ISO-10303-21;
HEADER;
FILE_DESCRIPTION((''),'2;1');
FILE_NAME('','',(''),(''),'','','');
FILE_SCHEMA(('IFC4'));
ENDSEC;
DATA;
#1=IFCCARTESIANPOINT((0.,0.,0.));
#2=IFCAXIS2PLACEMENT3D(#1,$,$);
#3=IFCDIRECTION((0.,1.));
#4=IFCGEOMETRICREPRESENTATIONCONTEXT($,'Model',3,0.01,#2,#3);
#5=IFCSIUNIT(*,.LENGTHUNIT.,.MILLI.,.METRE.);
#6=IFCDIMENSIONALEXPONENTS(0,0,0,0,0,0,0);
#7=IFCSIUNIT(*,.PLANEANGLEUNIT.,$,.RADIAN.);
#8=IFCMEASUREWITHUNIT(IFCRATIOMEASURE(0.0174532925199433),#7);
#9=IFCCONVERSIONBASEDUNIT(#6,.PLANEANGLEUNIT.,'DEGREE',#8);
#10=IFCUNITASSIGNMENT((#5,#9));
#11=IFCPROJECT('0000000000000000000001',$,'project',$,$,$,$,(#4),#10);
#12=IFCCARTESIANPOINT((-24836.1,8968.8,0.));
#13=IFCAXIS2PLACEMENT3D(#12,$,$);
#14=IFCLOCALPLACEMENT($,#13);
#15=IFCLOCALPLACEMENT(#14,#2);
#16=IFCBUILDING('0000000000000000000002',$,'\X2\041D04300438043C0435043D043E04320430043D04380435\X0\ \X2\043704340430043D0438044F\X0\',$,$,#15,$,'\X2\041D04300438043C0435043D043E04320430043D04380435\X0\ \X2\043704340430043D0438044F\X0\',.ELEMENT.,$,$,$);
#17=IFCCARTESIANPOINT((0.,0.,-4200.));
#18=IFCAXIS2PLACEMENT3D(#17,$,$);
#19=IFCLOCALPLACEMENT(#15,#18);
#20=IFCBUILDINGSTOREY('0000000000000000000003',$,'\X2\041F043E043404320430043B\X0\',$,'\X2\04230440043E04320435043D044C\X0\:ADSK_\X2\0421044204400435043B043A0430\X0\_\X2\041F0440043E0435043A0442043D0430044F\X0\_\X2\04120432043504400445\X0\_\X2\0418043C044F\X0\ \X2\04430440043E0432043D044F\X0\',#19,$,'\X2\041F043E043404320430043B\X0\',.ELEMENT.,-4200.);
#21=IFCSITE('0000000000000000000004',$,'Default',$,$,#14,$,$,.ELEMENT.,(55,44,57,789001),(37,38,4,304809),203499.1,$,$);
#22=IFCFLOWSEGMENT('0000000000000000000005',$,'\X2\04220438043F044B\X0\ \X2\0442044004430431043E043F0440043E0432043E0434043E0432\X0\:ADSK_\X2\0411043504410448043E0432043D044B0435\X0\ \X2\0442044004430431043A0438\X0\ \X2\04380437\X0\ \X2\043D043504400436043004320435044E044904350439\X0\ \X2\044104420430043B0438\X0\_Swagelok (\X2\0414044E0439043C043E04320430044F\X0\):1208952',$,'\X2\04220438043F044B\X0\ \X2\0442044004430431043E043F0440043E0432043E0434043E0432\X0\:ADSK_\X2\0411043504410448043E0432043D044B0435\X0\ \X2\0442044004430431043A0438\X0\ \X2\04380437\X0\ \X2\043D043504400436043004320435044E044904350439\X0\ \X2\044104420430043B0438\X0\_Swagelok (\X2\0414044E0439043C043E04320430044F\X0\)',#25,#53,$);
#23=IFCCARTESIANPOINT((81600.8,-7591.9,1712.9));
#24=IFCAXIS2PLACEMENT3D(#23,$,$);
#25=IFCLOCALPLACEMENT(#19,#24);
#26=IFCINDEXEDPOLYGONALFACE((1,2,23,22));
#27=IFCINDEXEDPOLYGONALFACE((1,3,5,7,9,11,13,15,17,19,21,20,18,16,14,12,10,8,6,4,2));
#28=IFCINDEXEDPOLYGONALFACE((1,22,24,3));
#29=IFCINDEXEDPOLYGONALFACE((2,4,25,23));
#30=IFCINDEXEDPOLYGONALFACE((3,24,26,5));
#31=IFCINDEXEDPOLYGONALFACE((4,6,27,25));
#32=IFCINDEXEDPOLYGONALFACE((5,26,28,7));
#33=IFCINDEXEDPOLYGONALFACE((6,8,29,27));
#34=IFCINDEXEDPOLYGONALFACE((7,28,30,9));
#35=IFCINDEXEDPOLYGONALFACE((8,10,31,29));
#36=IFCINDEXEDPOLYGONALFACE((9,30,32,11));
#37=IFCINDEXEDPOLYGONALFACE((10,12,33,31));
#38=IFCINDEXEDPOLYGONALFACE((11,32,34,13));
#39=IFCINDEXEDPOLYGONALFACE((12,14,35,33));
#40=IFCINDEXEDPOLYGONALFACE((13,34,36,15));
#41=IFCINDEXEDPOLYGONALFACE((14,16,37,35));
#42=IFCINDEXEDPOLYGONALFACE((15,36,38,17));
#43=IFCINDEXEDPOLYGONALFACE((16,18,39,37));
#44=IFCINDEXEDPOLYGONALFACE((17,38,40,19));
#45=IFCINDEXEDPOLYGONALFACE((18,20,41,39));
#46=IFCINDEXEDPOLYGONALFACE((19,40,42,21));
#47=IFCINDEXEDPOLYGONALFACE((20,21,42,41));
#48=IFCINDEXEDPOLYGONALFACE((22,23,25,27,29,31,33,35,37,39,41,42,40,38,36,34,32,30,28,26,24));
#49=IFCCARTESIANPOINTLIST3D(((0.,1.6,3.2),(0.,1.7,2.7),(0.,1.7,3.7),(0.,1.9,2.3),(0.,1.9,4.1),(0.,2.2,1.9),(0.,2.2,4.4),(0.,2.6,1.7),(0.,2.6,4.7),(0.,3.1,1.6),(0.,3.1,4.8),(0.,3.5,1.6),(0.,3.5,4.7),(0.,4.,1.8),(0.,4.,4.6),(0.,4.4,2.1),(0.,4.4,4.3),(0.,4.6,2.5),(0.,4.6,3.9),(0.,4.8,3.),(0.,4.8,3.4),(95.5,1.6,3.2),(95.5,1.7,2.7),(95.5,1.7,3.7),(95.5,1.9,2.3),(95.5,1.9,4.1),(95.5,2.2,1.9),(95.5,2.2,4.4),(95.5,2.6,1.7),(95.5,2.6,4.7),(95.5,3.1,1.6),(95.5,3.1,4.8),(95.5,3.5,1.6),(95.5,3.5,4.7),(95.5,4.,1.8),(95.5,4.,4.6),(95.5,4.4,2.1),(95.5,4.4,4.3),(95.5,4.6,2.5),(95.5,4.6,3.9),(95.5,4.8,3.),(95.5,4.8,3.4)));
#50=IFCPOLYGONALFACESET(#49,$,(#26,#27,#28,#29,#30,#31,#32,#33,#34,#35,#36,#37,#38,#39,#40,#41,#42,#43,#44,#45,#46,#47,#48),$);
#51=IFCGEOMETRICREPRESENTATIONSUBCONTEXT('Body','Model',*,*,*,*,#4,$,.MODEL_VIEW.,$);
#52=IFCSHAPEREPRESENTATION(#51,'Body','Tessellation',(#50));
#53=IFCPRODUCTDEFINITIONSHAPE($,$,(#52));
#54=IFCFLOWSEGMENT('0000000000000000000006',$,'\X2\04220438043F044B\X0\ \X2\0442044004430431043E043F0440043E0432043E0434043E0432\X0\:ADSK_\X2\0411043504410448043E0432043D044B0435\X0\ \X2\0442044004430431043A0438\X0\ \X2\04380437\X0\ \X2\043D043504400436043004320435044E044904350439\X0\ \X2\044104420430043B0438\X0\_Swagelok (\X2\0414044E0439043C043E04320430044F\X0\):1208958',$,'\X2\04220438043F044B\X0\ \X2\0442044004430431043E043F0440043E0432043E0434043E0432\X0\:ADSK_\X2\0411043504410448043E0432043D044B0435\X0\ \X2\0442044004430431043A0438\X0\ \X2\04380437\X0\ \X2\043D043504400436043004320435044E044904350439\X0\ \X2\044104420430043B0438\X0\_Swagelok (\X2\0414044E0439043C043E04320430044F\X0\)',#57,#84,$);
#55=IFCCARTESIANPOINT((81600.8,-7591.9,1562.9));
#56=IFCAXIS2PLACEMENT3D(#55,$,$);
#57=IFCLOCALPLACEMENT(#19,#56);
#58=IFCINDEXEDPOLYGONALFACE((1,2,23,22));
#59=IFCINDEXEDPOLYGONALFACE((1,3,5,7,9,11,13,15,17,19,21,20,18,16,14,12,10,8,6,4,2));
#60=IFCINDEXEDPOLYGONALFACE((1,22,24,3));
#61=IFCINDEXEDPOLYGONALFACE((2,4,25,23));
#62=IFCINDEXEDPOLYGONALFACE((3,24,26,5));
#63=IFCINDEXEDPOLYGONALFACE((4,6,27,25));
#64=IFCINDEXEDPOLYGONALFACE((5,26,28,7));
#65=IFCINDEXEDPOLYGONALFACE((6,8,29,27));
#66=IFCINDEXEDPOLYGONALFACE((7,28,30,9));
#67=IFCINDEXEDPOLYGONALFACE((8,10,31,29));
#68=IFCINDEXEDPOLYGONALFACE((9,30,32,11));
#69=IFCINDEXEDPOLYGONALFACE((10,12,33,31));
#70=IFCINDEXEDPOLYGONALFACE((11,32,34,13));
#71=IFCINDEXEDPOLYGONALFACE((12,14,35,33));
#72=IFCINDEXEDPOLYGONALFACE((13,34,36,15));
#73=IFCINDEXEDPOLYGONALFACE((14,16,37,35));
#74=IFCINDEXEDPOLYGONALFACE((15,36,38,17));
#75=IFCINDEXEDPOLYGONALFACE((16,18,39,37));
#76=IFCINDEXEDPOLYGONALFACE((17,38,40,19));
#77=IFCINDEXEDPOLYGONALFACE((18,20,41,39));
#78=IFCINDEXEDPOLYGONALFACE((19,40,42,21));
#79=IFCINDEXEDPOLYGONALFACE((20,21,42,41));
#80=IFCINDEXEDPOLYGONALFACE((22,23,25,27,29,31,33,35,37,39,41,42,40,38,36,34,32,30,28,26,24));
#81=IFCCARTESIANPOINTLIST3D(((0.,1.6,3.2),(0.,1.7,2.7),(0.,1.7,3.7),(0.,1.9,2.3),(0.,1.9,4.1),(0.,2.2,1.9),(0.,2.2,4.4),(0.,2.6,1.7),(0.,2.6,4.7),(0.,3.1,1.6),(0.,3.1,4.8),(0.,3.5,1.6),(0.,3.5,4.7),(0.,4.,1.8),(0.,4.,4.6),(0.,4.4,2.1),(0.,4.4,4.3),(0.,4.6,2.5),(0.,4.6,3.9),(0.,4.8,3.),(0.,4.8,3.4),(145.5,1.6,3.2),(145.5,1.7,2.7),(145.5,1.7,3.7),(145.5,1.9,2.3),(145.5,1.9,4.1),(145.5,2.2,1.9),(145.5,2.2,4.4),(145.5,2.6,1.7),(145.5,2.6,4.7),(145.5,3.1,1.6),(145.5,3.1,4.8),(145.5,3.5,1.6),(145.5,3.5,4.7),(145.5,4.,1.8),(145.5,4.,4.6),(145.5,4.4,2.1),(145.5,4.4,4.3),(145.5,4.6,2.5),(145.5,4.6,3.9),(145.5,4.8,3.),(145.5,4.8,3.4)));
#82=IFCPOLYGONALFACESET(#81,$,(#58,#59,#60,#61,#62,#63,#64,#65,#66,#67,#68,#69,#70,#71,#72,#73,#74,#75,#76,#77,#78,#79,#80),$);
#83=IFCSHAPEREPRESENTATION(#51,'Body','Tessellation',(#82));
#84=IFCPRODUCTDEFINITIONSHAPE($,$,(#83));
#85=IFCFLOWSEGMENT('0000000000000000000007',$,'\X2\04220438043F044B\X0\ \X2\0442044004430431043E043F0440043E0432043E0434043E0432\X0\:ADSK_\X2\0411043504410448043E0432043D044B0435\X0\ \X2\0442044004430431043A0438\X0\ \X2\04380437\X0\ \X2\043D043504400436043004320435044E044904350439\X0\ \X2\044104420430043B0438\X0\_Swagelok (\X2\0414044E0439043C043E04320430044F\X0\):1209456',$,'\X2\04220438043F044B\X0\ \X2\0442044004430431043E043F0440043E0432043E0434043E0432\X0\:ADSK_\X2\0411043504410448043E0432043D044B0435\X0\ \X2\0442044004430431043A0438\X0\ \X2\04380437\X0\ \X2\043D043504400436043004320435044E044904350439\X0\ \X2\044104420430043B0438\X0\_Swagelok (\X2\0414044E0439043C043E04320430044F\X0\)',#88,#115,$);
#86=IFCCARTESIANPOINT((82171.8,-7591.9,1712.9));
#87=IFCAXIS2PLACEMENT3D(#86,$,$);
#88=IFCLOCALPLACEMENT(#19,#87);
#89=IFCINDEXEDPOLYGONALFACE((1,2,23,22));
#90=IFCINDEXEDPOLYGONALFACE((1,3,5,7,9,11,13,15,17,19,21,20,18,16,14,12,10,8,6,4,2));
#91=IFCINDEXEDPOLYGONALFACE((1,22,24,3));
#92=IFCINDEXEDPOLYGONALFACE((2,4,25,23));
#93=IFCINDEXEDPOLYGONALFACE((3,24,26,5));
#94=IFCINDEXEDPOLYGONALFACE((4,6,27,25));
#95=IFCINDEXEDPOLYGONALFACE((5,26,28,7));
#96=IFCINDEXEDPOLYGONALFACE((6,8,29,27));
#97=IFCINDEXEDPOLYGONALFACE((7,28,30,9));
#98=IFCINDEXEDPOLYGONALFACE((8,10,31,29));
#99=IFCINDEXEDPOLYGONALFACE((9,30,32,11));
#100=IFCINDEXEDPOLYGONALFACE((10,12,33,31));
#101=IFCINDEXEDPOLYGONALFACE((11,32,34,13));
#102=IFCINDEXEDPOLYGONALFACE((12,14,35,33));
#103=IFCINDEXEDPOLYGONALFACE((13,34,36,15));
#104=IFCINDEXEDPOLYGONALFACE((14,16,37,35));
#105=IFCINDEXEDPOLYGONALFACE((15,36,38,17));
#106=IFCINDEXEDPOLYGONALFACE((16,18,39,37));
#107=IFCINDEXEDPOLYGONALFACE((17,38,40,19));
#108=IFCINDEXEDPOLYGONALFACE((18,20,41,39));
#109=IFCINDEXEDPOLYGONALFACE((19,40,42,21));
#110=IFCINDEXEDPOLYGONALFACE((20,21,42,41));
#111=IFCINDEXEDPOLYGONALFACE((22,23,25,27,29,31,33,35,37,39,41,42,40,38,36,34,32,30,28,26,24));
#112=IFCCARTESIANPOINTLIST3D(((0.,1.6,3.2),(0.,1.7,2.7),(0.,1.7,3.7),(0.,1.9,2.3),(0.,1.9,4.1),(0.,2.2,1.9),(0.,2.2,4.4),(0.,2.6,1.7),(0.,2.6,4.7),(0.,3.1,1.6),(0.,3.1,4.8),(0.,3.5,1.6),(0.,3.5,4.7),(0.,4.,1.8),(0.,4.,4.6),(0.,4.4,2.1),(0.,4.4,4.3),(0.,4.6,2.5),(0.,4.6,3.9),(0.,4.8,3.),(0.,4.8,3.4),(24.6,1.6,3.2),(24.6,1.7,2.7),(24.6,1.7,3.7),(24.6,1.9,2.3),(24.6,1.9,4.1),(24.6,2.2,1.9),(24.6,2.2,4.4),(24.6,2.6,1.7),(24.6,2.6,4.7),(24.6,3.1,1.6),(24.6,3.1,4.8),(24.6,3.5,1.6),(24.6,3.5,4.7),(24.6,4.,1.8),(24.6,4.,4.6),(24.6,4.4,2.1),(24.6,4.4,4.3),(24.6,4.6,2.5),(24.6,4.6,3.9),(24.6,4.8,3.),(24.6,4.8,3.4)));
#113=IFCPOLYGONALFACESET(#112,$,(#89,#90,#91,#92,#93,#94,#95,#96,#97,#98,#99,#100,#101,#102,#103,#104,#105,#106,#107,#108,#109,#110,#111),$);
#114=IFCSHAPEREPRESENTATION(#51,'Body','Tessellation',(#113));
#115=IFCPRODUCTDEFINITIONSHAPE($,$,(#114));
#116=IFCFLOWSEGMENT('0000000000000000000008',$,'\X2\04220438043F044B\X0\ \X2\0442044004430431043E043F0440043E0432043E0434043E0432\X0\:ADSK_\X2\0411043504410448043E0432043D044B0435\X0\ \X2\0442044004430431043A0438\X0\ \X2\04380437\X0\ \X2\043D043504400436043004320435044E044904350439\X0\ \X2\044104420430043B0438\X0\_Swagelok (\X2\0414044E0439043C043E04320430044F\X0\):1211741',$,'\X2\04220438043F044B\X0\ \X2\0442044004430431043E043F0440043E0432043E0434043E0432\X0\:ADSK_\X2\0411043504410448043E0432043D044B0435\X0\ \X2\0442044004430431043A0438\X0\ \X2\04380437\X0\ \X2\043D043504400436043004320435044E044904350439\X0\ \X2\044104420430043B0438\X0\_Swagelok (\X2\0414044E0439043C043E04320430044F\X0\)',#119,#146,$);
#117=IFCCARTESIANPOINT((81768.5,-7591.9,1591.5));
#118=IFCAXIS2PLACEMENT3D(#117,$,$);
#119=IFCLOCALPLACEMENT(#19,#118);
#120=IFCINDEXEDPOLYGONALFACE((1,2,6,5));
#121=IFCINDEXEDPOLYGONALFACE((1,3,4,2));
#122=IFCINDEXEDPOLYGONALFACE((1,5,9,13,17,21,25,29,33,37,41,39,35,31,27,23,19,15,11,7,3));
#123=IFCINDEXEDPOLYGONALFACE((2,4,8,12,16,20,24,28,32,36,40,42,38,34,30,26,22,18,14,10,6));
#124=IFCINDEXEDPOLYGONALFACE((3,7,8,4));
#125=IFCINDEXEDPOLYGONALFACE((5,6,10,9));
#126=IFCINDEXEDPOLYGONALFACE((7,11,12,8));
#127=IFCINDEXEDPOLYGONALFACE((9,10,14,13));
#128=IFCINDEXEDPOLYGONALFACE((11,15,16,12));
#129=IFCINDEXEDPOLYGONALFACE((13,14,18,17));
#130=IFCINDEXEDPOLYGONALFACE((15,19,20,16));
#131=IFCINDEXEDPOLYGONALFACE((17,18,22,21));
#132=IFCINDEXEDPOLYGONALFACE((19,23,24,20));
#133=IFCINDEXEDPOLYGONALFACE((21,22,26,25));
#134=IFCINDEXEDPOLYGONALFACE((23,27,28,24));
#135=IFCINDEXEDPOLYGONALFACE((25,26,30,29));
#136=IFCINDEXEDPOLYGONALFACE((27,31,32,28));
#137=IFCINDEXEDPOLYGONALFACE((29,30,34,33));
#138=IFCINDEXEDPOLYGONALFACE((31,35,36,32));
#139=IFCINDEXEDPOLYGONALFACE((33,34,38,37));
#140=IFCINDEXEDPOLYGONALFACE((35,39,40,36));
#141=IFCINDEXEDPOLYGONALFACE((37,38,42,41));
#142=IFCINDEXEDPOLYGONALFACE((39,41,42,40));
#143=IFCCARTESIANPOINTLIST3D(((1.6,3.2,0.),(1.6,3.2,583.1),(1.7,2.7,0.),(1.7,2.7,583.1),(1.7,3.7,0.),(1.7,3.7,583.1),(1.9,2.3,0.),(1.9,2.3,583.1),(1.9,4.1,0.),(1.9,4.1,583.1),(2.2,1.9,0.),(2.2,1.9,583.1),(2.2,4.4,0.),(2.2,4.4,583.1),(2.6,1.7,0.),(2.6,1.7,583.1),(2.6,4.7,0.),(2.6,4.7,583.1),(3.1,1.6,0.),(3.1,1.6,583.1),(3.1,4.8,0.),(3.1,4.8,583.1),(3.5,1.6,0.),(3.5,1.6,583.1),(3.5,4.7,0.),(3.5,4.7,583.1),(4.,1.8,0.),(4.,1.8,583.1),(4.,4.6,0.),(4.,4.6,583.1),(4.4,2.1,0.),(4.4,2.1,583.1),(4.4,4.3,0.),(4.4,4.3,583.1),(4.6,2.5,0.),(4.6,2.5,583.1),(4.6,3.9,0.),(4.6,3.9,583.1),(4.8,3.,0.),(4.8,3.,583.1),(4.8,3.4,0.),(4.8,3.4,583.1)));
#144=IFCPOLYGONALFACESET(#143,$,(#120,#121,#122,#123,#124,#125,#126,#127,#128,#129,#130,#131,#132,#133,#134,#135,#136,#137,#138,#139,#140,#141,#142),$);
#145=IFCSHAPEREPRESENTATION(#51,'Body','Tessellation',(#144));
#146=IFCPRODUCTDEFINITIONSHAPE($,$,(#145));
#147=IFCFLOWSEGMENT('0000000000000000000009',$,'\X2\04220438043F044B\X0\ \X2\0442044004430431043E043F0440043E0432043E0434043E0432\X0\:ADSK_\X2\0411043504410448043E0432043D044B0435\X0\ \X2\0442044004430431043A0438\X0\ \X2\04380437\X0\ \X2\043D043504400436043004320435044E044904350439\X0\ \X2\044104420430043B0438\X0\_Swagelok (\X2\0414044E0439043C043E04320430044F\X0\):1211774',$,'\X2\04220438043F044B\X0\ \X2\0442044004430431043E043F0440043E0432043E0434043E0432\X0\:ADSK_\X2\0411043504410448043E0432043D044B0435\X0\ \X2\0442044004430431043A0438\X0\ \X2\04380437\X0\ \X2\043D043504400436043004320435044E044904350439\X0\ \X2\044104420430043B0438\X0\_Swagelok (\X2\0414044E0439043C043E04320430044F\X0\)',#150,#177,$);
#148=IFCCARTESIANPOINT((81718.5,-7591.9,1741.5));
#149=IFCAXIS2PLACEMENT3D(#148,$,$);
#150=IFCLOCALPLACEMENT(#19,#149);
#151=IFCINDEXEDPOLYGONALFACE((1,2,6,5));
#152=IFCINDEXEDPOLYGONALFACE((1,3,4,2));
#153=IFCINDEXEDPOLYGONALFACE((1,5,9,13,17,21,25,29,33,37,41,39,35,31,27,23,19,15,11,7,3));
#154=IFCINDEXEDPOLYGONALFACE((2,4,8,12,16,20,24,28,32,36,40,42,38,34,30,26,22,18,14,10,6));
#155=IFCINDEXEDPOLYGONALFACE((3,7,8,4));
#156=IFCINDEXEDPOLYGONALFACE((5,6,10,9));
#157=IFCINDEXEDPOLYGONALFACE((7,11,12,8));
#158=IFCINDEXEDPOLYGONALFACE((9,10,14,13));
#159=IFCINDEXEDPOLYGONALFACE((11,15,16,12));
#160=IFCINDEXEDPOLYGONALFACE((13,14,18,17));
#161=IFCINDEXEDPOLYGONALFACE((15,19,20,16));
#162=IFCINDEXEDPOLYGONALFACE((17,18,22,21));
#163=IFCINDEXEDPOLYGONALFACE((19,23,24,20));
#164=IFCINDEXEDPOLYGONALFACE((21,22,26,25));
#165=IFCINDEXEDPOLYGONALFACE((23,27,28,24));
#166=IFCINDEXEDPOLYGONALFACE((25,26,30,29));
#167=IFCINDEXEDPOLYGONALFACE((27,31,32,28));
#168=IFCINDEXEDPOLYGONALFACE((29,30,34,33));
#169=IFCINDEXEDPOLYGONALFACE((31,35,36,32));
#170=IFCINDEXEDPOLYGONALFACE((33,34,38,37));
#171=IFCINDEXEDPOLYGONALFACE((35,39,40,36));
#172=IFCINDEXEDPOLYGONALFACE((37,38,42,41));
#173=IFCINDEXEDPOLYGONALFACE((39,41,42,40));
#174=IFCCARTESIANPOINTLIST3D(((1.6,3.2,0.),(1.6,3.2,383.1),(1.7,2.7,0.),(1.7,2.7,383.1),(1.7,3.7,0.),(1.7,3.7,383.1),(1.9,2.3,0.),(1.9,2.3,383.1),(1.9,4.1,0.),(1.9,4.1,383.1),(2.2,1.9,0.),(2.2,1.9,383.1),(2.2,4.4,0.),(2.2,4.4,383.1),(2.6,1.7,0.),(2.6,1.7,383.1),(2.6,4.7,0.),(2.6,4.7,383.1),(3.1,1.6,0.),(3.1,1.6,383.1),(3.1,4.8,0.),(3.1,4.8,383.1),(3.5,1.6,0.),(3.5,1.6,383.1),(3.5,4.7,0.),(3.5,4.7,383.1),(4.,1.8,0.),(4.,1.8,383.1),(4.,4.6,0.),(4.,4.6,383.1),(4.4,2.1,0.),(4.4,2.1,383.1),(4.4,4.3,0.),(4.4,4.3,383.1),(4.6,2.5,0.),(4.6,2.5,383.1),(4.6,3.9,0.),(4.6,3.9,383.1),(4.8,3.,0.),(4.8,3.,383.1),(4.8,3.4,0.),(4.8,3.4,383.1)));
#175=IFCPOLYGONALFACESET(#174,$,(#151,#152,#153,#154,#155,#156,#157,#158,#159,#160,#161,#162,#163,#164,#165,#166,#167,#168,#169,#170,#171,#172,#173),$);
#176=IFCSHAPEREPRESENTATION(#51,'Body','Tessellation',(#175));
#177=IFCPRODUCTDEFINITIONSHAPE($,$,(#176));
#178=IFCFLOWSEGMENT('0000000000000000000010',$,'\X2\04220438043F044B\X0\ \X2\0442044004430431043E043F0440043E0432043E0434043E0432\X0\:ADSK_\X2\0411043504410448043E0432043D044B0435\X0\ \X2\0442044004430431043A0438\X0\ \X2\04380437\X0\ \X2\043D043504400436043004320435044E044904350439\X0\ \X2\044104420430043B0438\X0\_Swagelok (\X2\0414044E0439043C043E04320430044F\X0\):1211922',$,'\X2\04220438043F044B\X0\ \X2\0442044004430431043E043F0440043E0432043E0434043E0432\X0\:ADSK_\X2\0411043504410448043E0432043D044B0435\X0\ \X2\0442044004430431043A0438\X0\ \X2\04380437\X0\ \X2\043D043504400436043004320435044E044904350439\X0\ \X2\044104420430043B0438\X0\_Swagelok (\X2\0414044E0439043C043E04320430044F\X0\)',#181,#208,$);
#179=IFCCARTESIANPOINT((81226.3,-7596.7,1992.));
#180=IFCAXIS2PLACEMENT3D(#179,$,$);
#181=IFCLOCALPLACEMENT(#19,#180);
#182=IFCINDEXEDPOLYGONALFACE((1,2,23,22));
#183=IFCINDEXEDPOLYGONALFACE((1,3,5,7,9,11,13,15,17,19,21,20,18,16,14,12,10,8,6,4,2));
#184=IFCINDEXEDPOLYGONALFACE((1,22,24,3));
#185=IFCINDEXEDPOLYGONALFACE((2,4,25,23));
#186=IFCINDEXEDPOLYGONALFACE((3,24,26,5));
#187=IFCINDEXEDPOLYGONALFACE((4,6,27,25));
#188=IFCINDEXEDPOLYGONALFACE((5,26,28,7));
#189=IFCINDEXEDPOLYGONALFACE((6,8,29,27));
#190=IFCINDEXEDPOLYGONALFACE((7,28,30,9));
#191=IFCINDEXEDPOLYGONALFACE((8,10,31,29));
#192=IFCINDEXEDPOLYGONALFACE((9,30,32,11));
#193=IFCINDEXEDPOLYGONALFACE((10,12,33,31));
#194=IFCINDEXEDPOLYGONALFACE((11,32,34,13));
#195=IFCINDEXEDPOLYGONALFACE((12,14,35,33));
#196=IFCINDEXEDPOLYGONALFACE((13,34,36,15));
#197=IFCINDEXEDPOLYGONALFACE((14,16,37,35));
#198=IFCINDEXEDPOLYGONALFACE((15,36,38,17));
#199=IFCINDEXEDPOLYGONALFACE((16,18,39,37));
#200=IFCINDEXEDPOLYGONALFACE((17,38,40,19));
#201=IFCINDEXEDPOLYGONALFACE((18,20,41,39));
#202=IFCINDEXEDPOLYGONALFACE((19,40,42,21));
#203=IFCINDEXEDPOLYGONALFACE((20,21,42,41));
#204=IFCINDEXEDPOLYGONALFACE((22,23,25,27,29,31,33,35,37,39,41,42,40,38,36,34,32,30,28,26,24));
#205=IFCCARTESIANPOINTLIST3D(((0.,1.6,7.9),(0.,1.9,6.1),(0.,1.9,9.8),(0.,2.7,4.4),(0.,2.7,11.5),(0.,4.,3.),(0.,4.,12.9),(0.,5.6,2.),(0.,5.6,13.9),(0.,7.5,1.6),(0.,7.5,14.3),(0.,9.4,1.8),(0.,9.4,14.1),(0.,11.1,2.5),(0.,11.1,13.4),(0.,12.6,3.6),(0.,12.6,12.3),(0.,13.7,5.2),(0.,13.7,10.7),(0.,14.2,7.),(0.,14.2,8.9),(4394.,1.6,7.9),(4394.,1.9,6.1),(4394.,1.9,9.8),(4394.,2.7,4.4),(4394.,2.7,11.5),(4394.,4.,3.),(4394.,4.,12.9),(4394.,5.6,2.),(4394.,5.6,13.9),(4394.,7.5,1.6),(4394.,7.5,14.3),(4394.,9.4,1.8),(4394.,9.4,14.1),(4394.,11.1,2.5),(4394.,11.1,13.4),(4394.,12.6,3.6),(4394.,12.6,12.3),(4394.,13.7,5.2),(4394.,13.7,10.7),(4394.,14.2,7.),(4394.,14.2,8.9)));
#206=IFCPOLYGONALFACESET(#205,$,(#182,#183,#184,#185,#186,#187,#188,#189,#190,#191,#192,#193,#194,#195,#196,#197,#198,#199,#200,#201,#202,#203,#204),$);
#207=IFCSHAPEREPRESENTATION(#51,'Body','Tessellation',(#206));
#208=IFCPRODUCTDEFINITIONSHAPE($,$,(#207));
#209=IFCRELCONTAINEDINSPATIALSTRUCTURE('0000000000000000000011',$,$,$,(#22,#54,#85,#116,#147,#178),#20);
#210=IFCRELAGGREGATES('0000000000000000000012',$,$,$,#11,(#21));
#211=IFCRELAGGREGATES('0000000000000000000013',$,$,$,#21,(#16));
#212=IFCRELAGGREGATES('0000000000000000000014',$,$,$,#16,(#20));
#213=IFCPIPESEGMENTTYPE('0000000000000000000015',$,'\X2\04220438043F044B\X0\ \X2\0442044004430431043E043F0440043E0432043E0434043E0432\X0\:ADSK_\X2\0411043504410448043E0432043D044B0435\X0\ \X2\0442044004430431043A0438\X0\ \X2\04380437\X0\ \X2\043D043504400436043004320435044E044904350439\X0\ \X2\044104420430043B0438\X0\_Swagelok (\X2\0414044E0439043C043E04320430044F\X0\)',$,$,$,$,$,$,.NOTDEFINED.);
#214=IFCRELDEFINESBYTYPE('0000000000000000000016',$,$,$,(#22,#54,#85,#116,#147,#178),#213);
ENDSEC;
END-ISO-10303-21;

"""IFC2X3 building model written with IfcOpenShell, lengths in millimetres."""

from ifc_helpers import new_model, entity, si_unit, converted_unit, direction, frame, origin, origin_2d_with_axis, place, context, subcontext, project, spatial, circle, extrude, type_object, element, save


model = new_model("IFC2X3")

# Units and contexts
model_context = context("Model", 3, precision=0.01, world=origin(), true_north=direction((0.0, 1.0)))
body_context = subcontext(model_context, "Body", "Model", "MODEL_VIEW")
ifc_project = project(units=[si_unit("LENGTHUNIT", "METRE", prefix="MILLI"), converted_unit("PLANEANGLEUNIT", "DEGREE", entity("IfcRatioMeasure", 0.0174532925199433), si_unit("PLANEANGLEUNIT", "RADIAN"), dimensions=[0, 0, 0, 0, 0, 0, 0])], contexts=[model_context])

# Site, building, storey
site_placement = place(None, frame((-24836.1, 8968.8, 0.0)))
site = spatial("IfcSite", under=ifc_project, at=site_placement, Name="Default", CompositionType="ELEMENT", RefLatitude=(55, 44, 57, 789001), RefLongitude=(37, 38, 4, 304809), RefElevation=203499.1)
building_placement = place(site_placement, origin())
building = spatial("IfcBuilding", under=site, at=building_placement, Name="Наименование здания", LongName="Наименование здания", CompositionType="ELEMENT")
storey_placement = place(building_placement, frame((0.0, 0.0, -4200.0)))
storey = spatial("IfcBuildingStorey", under=building, at=storey_placement, Name="Подвал", ObjectType="Уровень:ADSK_Стрелка_Проектная_Вверх_Имя уровня", LongName="Подвал", CompositionType="ELEMENT", Elevation=-4200.0)

# Flow segments
pipe_segment_type = type_object("IfcPipeSegmentType", Name="Типы трубопроводов:ADSK_Бесшовные трубки из нержавеющей стали_Swagelok (Дюймовая)", PredefinedType="NOTDEFINED")
flow_segment_1_placement = place(storey_placement, frame((81600.8, -7591.9, 1712.9)))
element("IfcFlowSegment", 1, at=flow_segment_1_placement, inside=storey, type_object=pipe_segment_type, Name="Типы трубопроводов:ADSK_Бесшовные трубки из нержавеющей стали_Swagelok (Дюймовая):1208952", ObjectType="Типы трубопроводов:ADSK_Бесшовные трубки из нержавеющей стали_Swagelok (Дюймовая)", context=body_context, shape_type="SweptSolid", body=[
    extrude(circle(Radius=1.6, at=origin_2d_with_axis()), frame((0.0, 3.2, 3.2), z_axis=(1.0, 0.0, 0.0), x_axis=(0.0, -1.0, 0.0)), (0.0, 0.0, 1.0), 95.5),
])
flow_segment_2_placement = place(storey_placement, frame((81600.8, -7591.9, 1562.9)))
element("IfcFlowSegment", 2, at=flow_segment_2_placement, inside=storey, type_object=pipe_segment_type, Name="Типы трубопроводов:ADSK_Бесшовные трубки из нержавеющей стали_Swagelok (Дюймовая):1208958", ObjectType="Типы трубопроводов:ADSK_Бесшовные трубки из нержавеющей стали_Swagelok (Дюймовая)", context=body_context, shape_type="SweptSolid", body=[
    extrude(circle(Radius=1.6, at=origin_2d_with_axis()), frame((0.0, 3.2, 3.2), z_axis=(1.0, 0.0, 0.0), x_axis=(0.0, -1.0, 0.0)), (0.0, 0.0, 1.0), 145.5),
])
flow_segment_3_placement = place(storey_placement, frame((82171.8, -7591.9, 1712.9)))
element("IfcFlowSegment", 3, at=flow_segment_3_placement, inside=storey, type_object=pipe_segment_type, Name="Типы трубопроводов:ADSK_Бесшовные трубки из нержавеющей стали_Swagelok (Дюймовая):1209456", ObjectType="Типы трубопроводов:ADSK_Бесшовные трубки из нержавеющей стали_Swagelok (Дюймовая)", context=body_context, shape_type="SweptSolid", body=[
    extrude(circle(Radius=1.6, at=origin_2d_with_axis()), frame((0.0, 3.2, 3.2), z_axis=(1.0, 0.0, 0.0), x_axis=(0.0, -1.0, 0.0)), (0.0, 0.0, 1.0), 24.6),
])
flow_segment_4_placement = place(storey_placement, frame((81768.5, -7591.9, 1591.5)))
element("IfcFlowSegment", 4, at=flow_segment_4_placement, inside=storey, type_object=pipe_segment_type, Name="Типы трубопроводов:ADSK_Бесшовные трубки из нержавеющей стали_Swagelok (Дюймовая):1211741", ObjectType="Типы трубопроводов:ADSK_Бесшовные трубки из нержавеющей стали_Swagelok (Дюймовая)", context=body_context, shape_type="SweptSolid", body=[
    extrude(circle(Radius=1.6, at=origin_2d_with_axis()), frame((3.2, 3.2, 0.0), z_axis=(0.0, 0.0, 1.0), x_axis=(-1.0, 0.0, 0.0)), (0.0, 0.0, 1.0), 583.1),
])
flow_segment_5_placement = place(storey_placement, frame((81718.5, -7591.9, 1741.5)))
element("IfcFlowSegment", 5, at=flow_segment_5_placement, inside=storey, type_object=pipe_segment_type, Name="Типы трубопроводов:ADSK_Бесшовные трубки из нержавеющей стали_Swagelok (Дюймовая):1211774", ObjectType="Типы трубопроводов:ADSK_Бесшовные трубки из нержавеющей стали_Swagelok (Дюймовая)", context=body_context, shape_type="SweptSolid", body=[
    extrude(circle(Radius=1.6, at=origin_2d_with_axis()), frame((3.2, 3.2, 0.0), z_axis=(0.0, 0.0, 1.0), x_axis=(-1.0, 0.0, 0.0)), (0.0, 0.0, 1.0), 383.1),
])
flow_segment_6_placement = place(storey_placement, frame((81226.3, -7596.7, 1992.0)))
element("IfcFlowSegment", 6, at=flow_segment_6_placement, inside=storey, type_object=pipe_segment_type, Name="Типы трубопроводов:ADSK_Бесшовные трубки из нержавеющей стали_Swagelok (Дюймовая):1211922", ObjectType="Типы трубопроводов:ADSK_Бесшовные трубки из нержавеющей стали_Swagelok (Дюймовая)", context=body_context, shape_type="SweptSolid", body=[
    extrude(circle(Radius=6.3, at=origin_2d_with_axis()), frame((0.0, 8.0, 8.0), z_axis=(1.0, 0.0, 0.0), x_axis=(0.0, -1.0, 0.0)), (0.0, 0.0, 1.0), 4394.0),
])

save(model, "model.ifc")
